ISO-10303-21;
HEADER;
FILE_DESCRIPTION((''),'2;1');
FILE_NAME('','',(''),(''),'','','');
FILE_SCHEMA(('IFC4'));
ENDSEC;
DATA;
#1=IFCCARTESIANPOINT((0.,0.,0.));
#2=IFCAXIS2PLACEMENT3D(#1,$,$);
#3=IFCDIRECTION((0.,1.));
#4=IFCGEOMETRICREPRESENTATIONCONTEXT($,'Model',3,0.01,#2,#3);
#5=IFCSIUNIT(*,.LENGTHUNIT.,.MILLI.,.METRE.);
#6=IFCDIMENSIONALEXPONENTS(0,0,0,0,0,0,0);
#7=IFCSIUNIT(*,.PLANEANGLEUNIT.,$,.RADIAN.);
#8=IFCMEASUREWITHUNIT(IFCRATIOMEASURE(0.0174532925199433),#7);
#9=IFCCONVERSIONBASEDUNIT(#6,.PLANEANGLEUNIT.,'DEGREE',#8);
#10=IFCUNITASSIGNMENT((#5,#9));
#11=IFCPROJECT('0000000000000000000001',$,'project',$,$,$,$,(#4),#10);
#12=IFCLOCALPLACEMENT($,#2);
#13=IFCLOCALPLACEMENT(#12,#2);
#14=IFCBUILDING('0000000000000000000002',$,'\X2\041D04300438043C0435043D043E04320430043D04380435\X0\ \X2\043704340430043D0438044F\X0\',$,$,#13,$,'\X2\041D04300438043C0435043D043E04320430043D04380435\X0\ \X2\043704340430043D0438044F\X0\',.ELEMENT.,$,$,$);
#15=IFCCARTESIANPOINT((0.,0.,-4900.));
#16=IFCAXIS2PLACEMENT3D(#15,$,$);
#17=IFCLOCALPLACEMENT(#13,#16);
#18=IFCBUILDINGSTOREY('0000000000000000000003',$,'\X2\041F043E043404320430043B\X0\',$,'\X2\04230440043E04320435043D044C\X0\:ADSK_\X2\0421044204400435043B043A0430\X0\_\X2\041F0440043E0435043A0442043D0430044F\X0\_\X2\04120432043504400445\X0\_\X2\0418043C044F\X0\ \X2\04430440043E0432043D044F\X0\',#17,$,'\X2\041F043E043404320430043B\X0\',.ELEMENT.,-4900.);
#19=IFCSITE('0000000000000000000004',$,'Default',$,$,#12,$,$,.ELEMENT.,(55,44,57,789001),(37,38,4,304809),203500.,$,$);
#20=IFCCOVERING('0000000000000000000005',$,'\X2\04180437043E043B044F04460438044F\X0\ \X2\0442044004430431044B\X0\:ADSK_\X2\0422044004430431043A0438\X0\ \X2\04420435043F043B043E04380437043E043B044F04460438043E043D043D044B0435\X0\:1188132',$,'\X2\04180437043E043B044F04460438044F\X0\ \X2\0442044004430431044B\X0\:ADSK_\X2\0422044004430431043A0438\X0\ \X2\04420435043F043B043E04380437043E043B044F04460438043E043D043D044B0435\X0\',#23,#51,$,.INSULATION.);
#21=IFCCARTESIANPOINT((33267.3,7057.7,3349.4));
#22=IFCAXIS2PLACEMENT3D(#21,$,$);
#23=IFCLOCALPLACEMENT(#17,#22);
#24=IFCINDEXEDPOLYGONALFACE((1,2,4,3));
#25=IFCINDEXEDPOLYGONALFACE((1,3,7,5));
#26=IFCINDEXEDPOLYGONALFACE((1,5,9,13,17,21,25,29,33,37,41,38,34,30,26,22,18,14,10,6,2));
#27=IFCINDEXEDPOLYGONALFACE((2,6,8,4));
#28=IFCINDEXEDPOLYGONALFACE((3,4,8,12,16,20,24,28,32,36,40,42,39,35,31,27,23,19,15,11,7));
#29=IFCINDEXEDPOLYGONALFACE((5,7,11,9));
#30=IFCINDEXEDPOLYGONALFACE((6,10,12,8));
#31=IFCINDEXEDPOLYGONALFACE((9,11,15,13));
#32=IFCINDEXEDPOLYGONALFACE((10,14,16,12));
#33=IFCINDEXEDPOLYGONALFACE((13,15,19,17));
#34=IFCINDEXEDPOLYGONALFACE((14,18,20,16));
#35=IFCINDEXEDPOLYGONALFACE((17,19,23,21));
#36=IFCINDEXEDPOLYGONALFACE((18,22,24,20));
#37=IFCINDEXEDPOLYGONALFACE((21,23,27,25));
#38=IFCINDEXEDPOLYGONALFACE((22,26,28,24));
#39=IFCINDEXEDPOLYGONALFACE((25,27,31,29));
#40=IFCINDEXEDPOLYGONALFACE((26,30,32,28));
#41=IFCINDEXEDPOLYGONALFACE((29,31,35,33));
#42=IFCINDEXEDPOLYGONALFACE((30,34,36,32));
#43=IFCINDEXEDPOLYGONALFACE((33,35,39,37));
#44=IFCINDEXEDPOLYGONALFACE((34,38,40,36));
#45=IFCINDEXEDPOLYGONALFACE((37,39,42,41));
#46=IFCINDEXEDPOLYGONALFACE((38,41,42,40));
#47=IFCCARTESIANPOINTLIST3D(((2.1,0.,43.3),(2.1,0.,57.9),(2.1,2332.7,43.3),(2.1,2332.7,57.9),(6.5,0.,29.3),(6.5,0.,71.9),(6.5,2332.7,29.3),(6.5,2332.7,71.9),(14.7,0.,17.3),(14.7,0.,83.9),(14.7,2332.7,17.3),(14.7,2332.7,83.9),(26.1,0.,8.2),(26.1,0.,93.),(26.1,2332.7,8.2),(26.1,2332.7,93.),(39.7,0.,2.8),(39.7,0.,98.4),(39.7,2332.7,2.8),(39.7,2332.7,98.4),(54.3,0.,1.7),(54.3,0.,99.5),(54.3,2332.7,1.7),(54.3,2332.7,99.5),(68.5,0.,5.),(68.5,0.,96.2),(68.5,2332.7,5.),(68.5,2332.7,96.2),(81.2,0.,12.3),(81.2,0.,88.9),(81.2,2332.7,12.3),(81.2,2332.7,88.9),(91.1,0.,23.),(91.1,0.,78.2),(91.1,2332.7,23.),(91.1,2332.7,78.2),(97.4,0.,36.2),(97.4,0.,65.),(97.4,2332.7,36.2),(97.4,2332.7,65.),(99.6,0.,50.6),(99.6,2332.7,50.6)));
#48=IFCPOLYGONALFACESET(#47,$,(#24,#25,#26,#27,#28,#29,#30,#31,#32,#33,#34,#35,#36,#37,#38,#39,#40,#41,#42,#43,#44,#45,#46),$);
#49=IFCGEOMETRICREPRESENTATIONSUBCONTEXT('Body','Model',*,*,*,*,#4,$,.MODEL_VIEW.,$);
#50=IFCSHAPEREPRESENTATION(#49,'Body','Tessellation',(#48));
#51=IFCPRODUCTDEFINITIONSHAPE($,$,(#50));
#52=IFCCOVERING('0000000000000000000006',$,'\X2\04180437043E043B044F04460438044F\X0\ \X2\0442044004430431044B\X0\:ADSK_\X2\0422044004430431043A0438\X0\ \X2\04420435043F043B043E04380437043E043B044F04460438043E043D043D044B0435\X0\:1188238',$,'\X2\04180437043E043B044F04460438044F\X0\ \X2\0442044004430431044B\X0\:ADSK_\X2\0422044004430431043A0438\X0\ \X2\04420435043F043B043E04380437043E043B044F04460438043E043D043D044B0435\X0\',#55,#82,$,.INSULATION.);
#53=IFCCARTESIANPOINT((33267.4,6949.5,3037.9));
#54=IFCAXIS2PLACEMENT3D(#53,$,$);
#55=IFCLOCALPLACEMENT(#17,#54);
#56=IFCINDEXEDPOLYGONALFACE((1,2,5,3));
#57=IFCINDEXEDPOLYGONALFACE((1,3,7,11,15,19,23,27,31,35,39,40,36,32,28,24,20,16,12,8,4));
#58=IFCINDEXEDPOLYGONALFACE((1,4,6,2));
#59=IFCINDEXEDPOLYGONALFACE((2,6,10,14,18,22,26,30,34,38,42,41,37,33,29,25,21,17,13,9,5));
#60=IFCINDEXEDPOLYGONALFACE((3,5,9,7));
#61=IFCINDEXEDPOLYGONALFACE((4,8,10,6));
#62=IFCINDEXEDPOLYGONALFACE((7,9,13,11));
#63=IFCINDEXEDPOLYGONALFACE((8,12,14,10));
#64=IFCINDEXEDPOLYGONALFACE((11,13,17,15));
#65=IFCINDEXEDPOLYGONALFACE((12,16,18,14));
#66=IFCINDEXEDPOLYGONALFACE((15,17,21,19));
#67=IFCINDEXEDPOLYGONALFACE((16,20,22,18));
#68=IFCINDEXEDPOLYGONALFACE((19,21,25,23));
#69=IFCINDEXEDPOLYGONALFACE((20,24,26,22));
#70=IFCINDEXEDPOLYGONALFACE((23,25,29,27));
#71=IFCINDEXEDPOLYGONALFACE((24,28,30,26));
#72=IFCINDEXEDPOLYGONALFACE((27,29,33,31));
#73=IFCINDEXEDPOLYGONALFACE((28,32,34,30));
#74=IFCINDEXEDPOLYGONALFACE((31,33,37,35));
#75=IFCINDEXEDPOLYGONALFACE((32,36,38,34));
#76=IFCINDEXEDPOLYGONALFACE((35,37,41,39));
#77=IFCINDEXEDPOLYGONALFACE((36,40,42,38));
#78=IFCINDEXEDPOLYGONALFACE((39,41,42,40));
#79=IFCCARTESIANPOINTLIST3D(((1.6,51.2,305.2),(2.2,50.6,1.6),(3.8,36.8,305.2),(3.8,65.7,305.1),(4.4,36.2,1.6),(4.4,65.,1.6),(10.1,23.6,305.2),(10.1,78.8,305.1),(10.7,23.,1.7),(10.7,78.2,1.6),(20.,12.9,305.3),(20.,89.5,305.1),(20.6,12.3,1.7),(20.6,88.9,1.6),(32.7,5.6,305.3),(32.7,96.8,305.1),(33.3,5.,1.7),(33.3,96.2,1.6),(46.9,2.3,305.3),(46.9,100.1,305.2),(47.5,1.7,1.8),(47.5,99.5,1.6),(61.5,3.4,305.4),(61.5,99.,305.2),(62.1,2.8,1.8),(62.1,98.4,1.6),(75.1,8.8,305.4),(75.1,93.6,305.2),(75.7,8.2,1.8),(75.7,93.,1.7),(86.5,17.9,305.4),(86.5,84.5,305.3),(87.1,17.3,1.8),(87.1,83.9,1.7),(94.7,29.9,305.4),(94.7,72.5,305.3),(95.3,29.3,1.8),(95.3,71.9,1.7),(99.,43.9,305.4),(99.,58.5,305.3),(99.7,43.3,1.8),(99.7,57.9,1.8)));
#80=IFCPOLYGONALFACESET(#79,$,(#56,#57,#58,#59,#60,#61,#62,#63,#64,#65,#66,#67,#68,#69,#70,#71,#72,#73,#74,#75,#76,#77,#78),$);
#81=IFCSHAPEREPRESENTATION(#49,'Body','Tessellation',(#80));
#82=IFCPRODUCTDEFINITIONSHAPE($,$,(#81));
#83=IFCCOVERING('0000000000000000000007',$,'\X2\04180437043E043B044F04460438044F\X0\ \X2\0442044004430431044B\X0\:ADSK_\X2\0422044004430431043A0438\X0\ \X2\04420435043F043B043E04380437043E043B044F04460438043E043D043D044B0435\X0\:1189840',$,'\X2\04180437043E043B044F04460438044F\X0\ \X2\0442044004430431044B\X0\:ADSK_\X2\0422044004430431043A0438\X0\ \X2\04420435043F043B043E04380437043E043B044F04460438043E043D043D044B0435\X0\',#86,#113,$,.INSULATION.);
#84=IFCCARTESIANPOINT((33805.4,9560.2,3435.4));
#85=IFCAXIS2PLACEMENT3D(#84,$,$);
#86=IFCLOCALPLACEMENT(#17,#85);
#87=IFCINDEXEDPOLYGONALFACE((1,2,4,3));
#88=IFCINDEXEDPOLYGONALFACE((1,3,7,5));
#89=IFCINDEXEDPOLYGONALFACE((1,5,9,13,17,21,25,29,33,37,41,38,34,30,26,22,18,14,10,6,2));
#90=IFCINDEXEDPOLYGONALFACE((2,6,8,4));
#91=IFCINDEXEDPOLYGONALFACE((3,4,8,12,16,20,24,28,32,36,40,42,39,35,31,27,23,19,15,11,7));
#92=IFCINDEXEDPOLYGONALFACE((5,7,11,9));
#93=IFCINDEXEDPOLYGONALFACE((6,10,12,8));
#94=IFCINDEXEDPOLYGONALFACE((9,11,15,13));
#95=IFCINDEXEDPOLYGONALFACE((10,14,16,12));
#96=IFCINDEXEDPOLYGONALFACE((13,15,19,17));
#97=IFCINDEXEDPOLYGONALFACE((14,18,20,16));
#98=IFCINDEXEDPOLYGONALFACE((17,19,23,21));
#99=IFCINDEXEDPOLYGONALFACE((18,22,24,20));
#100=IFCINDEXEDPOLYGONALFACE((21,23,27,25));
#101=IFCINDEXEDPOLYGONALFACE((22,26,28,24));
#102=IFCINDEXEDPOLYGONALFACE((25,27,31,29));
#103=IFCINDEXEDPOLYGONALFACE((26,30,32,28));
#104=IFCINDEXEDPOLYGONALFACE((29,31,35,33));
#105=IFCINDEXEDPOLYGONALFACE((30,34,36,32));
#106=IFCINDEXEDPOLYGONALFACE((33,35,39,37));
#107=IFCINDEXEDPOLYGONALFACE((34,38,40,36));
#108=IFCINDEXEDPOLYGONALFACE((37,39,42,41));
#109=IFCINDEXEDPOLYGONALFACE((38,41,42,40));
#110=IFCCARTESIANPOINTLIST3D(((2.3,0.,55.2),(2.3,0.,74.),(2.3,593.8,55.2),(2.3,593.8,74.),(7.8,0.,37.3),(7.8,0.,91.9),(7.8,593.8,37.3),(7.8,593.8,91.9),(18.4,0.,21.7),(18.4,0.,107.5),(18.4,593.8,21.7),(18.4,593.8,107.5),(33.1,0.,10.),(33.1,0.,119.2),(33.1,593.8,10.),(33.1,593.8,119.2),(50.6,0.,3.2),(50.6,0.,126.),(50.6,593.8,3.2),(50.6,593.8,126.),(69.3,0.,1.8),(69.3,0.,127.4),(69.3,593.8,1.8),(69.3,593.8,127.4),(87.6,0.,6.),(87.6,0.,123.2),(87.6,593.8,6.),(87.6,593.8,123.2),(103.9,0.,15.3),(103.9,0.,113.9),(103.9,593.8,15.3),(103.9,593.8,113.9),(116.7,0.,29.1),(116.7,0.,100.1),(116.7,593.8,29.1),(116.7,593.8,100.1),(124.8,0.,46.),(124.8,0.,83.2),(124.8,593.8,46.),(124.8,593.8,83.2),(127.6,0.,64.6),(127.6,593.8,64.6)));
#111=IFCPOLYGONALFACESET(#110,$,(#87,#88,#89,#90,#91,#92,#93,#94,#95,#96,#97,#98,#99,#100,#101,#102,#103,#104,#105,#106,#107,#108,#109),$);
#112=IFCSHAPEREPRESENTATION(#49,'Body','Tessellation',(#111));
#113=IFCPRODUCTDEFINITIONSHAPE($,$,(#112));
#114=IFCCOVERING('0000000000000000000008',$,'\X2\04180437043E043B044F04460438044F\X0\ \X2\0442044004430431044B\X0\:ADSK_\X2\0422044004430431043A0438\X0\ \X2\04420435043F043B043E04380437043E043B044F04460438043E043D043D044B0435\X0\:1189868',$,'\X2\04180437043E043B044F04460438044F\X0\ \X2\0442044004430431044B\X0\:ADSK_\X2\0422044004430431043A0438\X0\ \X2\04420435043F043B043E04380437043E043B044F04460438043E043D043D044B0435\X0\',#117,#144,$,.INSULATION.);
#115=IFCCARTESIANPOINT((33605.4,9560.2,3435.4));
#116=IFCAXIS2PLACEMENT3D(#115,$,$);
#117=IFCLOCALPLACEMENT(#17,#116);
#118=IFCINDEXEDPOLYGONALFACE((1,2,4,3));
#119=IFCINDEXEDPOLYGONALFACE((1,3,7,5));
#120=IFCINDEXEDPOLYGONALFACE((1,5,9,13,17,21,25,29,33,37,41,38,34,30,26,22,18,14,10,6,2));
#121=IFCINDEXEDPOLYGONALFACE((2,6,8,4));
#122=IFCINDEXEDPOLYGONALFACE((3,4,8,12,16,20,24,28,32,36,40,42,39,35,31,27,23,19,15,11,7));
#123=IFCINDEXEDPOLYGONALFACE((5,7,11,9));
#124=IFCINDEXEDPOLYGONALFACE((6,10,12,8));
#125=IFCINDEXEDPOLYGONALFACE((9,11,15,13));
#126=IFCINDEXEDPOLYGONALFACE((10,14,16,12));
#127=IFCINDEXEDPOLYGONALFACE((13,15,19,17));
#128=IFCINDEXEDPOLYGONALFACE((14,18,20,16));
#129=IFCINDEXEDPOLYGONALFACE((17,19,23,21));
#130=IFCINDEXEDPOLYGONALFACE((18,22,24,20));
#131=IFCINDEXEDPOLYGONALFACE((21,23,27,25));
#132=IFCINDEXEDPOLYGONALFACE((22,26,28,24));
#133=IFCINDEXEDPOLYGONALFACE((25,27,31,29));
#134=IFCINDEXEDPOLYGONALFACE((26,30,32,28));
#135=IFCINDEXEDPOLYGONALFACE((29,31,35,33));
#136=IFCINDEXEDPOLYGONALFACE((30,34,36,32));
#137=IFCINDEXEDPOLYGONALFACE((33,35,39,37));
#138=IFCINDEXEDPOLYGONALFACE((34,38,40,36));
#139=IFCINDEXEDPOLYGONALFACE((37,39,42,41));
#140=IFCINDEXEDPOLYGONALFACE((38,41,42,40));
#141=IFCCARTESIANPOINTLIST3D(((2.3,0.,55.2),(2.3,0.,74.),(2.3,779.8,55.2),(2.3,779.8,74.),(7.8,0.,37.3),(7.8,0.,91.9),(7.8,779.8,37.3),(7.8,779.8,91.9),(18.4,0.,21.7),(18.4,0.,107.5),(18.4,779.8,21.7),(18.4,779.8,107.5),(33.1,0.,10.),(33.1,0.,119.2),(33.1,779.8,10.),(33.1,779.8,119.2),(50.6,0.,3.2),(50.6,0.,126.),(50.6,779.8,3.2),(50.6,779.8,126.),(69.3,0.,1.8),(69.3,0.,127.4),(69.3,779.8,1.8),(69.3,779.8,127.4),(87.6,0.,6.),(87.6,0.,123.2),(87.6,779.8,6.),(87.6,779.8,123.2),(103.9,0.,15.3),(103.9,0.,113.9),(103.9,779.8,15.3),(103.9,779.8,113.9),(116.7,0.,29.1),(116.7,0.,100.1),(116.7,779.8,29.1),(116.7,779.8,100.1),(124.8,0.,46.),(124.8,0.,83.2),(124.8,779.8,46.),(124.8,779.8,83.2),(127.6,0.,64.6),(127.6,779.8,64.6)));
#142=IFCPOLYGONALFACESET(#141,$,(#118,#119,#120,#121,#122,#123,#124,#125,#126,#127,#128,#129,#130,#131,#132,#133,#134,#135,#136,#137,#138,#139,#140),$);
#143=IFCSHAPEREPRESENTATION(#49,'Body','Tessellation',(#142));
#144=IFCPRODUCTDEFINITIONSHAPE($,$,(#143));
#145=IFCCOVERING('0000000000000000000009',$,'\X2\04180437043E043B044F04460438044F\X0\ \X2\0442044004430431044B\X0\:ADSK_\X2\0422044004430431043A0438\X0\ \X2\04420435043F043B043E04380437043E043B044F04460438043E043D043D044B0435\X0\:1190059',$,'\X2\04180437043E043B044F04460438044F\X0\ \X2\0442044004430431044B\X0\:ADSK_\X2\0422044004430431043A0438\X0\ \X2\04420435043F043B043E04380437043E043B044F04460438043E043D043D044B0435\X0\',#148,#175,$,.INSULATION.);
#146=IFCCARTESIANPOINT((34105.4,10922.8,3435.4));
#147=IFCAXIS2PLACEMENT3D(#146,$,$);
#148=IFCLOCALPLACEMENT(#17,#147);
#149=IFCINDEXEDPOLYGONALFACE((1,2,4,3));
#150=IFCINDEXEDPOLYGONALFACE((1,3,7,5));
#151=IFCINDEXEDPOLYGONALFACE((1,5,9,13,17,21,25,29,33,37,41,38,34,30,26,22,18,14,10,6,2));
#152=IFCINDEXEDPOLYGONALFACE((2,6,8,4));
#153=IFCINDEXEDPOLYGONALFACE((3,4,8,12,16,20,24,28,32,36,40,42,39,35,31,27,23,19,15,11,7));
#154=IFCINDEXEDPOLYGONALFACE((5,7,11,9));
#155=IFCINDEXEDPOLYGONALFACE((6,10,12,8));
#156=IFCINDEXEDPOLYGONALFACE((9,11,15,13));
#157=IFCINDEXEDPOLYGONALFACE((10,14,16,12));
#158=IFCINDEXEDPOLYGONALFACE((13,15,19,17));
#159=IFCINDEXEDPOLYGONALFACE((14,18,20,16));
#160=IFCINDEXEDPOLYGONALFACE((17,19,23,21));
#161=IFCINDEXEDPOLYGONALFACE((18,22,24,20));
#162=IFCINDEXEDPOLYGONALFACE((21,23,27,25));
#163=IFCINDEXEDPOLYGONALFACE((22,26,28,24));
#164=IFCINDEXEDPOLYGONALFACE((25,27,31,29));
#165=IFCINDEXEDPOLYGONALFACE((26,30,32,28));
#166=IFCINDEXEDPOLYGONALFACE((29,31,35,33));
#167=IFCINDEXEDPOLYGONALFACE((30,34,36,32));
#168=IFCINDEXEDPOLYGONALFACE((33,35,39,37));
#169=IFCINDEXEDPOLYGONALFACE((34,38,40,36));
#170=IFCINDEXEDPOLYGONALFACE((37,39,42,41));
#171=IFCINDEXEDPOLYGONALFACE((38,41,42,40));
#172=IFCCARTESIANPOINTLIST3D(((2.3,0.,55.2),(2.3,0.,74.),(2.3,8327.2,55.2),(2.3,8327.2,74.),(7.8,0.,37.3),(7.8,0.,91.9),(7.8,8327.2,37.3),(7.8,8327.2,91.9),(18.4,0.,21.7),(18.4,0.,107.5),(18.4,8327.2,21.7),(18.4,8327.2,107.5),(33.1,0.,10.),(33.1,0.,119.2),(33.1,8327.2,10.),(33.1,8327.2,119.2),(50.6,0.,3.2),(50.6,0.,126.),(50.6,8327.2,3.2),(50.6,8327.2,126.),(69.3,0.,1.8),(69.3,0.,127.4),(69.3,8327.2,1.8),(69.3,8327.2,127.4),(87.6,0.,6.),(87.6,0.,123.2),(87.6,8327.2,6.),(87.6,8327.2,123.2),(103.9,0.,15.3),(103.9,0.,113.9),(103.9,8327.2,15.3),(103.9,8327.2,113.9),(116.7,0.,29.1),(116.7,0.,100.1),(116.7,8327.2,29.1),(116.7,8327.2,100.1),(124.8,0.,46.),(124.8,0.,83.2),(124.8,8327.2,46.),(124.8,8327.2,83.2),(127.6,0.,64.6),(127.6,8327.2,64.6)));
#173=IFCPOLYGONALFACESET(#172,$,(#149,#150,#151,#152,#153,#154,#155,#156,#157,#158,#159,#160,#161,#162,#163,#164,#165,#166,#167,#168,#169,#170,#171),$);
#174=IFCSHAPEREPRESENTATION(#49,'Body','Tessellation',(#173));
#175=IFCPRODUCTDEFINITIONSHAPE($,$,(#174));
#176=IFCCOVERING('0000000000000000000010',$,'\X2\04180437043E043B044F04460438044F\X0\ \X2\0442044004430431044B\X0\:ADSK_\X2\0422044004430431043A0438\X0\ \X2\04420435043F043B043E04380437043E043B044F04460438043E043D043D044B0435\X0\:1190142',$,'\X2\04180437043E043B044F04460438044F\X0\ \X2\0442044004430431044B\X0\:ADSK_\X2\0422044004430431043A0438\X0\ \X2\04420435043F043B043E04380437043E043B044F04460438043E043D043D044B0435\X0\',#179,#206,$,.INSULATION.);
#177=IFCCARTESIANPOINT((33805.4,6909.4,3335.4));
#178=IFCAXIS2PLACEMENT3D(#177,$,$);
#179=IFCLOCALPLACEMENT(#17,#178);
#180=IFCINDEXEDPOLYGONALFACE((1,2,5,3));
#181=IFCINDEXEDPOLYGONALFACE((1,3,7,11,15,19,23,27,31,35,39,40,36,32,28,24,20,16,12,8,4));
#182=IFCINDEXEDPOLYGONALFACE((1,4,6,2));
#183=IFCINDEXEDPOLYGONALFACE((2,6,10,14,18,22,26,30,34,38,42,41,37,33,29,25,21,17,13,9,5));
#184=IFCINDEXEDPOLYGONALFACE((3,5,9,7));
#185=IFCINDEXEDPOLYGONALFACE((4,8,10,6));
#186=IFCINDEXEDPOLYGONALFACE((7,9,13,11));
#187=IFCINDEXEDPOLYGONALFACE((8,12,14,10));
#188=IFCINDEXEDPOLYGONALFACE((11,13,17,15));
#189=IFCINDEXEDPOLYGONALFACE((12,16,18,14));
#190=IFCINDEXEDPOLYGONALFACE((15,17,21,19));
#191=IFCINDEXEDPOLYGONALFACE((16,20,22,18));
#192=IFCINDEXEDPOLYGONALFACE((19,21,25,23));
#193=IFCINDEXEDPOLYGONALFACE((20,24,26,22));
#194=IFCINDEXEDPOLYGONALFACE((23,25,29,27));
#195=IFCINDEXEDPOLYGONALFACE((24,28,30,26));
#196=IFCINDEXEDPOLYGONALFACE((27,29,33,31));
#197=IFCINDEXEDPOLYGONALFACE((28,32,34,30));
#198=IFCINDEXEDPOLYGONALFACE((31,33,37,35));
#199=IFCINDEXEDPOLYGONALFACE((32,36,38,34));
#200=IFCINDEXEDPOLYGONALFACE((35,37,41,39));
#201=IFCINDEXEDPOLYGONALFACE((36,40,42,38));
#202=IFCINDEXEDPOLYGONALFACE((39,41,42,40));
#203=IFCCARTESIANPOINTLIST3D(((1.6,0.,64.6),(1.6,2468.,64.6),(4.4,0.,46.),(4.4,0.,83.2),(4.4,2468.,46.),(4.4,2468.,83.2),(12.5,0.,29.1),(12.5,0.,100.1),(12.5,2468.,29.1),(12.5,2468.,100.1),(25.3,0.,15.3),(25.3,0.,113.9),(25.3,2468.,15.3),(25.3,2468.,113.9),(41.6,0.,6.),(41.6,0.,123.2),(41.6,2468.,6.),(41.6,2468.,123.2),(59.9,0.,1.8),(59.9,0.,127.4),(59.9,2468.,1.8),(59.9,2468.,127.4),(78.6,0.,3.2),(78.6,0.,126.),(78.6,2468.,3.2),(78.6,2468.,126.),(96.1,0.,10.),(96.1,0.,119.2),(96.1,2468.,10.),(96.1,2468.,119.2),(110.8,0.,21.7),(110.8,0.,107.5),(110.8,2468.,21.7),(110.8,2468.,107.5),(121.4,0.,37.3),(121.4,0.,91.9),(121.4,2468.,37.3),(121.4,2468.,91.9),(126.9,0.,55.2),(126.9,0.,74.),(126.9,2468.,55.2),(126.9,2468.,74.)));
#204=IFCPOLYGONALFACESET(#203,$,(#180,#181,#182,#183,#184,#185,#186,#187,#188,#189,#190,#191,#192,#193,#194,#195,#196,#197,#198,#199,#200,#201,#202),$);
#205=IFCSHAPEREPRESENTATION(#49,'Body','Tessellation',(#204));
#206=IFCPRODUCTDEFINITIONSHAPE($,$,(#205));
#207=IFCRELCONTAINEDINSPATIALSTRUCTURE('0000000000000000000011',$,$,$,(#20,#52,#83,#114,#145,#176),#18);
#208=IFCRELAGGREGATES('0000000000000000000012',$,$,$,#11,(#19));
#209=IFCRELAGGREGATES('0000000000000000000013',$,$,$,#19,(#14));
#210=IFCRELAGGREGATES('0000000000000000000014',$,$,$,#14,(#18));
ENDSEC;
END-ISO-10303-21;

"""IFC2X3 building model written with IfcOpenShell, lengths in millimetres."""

from ifc_helpers import new_model, entity, si_unit, converted_unit, direction, frame, origin, origin_2d_with_axis, place, context, subcontext, project, spatial, circle, extrude, element, save


model = new_model("IFC2X3")

# Units and contexts
model_context = context("Model", 3, precision=0.01, world=origin(), true_north=direction((0.0, 1.0)))
body_context = subcontext(model_context, "Body", "Model", "MODEL_VIEW")
ifc_project = project(units=[si_unit("LENGTHUNIT", "METRE", prefix="MILLI"), converted_unit("PLANEANGLEUNIT", "DEGREE", entity("IfcRatioMeasure", 0.0174532925199433), si_unit("PLANEANGLEUNIT", "RADIAN"), dimensions=[0, 0, 0, 0, 0, 0, 0])], contexts=[model_context])

# Site, building, storey
site_placement = place(None, origin())
site = spatial("IfcSite", under=ifc_project, at=site_placement, Name="Default", CompositionType="ELEMENT", RefLatitude=(55, 44, 57, 789001), RefLongitude=(37, 38, 4, 304809), RefElevation=203500.0)
building_placement = place(site_placement, origin())
building = spatial("IfcBuilding", under=site, at=building_placement, Name="Наименование здания", LongName="Наименование здания", CompositionType="ELEMENT")
storey_placement = place(building_placement, frame((0.0, 0.0, -4900.0)))
storey = spatial("IfcBuildingStorey", under=building, at=storey_placement, Name="Подвал", ObjectType="Уровень:ADSK_Стрелка_Проектная_Вверх_Имя уровня", LongName="Подвал", CompositionType="ELEMENT", Elevation=-4900.0)

# Coverings
covering_1_placement = place(storey_placement, frame((33267.3, 7057.7, 3349.4)))
element("IfcCovering", 1, at=covering_1_placement, inside=storey, Name="Изоляция трубы:ADSK_Трубки теплоизоляционные:1188132", ObjectType="Изоляция трубы:ADSK_Трубки теплоизоляционные", PredefinedType="INSULATION", context=body_context, shape_type="SweptSolid", body=[
    extrude(circle(Radius=49.0, at=origin_2d_with_axis()), frame((50.6, 0.0, 50.6), z_axis=(0.0, 1.0, 0.0), x_axis=(1.0, 0.0, 0.0)), (0.0, 0.0, 1.0), 2332.7),
])
covering_2_placement = place(storey_placement, frame((33267.4, 6949.5, 3037.9)))
element("IfcCovering", 2, at=covering_2_placement, inside=storey, Name="Изоляция трубы:ADSK_Трубки теплоизоляционные:1188238", ObjectType="Изоляция трубы:ADSK_Трубки теплоизоляционные", PredefinedType="INSULATION", context=body_context, shape_type="SweptSolid", body=[
    extrude(circle(Radius=49.0, at=origin_2d_with_axis()), frame((51.2, 50.6, 1.7), z_axis=(-0.002, 0.002, 0.999996), x_axis=(-0.999998, 0.0, -0.002)), (0.0, 0.0, 1.0), 303.6),
])
covering_3_placement = place(storey_placement, frame((33805.4, 9560.2, 3435.4)))
element("IfcCovering", 3, at=covering_3_placement, inside=storey, Name="Изоляция трубы:ADSK_Трубки теплоизоляционные:1189840", ObjectType="Изоляция трубы:ADSK_Трубки теплоизоляционные", PredefinedType="INSULATION", context=body_context, shape_type="SweptSolid", body=[
    extrude(circle(Radius=63.0, at=origin_2d_with_axis()), frame((64.6, 0.0, 64.6), z_axis=(0.0, 1.0, 0.0), x_axis=(1.0, 0.0, 0.0)), (0.0, 0.0, 1.0), 593.8),
])
covering_4_placement = place(storey_placement, frame((33605.4, 9560.2, 3435.4)))
element("IfcCovering", 4, at=covering_4_placement, inside=storey, Name="Изоляция трубы:ADSK_Трубки теплоизоляционные:1189868", ObjectType="Изоляция трубы:ADSK_Трубки теплоизоляционные", PredefinedType="INSULATION", context=body_context, shape_type="SweptSolid", body=[
    extrude(circle(Radius=63.0, at=origin_2d_with_axis()), frame((64.6, 0.0, 64.6), z_axis=(0.0, 1.0, 0.0), x_axis=(1.0, 0.0, 0.0)), (0.0, 0.0, 1.0), 779.8),
])
covering_5_placement = place(storey_placement, frame((34105.4, 10922.8, 3435.4)))
element("IfcCovering", 5, at=covering_5_placement, inside=storey, Name="Изоляция трубы:ADSK_Трубки теплоизоляционные:1190059", ObjectType="Изоляция трубы:ADSK_Трубки теплоизоляционные", PredefinedType="INSULATION", context=body_context, shape_type="SweptSolid", body=[
    extrude(circle(Radius=63.0, at=origin_2d_with_axis()), frame((64.6, 0.0, 64.6), z_axis=(0.0, 1.0, 0.0), x_axis=(1.0, 0.0, 0.0)), (0.0, 0.0, 1.0), 8327.2),
])
covering_6_placement = place(storey_placement, frame((33805.4, 6909.4, 3335.4)))
element("IfcCovering", 6, at=covering_6_placement, inside=storey, Name="Изоляция трубы:ADSK_Трубки теплоизоляционные:1190142", ObjectType="Изоляция трубы:ADSK_Трубки теплоизоляционные", PredefinedType="INSULATION", context=body_context, shape_type="SweptSolid", body=[
    extrude(circle(Radius=63.0, at=origin_2d_with_axis()), frame((64.6, 0.0, 64.6), z_axis=(0.0, 1.0, 0.0), x_axis=(-1.0, 0.0, 0.0)), (0.0, 0.0, 1.0), 2468.0),
])

save(model, "model.ifc")
